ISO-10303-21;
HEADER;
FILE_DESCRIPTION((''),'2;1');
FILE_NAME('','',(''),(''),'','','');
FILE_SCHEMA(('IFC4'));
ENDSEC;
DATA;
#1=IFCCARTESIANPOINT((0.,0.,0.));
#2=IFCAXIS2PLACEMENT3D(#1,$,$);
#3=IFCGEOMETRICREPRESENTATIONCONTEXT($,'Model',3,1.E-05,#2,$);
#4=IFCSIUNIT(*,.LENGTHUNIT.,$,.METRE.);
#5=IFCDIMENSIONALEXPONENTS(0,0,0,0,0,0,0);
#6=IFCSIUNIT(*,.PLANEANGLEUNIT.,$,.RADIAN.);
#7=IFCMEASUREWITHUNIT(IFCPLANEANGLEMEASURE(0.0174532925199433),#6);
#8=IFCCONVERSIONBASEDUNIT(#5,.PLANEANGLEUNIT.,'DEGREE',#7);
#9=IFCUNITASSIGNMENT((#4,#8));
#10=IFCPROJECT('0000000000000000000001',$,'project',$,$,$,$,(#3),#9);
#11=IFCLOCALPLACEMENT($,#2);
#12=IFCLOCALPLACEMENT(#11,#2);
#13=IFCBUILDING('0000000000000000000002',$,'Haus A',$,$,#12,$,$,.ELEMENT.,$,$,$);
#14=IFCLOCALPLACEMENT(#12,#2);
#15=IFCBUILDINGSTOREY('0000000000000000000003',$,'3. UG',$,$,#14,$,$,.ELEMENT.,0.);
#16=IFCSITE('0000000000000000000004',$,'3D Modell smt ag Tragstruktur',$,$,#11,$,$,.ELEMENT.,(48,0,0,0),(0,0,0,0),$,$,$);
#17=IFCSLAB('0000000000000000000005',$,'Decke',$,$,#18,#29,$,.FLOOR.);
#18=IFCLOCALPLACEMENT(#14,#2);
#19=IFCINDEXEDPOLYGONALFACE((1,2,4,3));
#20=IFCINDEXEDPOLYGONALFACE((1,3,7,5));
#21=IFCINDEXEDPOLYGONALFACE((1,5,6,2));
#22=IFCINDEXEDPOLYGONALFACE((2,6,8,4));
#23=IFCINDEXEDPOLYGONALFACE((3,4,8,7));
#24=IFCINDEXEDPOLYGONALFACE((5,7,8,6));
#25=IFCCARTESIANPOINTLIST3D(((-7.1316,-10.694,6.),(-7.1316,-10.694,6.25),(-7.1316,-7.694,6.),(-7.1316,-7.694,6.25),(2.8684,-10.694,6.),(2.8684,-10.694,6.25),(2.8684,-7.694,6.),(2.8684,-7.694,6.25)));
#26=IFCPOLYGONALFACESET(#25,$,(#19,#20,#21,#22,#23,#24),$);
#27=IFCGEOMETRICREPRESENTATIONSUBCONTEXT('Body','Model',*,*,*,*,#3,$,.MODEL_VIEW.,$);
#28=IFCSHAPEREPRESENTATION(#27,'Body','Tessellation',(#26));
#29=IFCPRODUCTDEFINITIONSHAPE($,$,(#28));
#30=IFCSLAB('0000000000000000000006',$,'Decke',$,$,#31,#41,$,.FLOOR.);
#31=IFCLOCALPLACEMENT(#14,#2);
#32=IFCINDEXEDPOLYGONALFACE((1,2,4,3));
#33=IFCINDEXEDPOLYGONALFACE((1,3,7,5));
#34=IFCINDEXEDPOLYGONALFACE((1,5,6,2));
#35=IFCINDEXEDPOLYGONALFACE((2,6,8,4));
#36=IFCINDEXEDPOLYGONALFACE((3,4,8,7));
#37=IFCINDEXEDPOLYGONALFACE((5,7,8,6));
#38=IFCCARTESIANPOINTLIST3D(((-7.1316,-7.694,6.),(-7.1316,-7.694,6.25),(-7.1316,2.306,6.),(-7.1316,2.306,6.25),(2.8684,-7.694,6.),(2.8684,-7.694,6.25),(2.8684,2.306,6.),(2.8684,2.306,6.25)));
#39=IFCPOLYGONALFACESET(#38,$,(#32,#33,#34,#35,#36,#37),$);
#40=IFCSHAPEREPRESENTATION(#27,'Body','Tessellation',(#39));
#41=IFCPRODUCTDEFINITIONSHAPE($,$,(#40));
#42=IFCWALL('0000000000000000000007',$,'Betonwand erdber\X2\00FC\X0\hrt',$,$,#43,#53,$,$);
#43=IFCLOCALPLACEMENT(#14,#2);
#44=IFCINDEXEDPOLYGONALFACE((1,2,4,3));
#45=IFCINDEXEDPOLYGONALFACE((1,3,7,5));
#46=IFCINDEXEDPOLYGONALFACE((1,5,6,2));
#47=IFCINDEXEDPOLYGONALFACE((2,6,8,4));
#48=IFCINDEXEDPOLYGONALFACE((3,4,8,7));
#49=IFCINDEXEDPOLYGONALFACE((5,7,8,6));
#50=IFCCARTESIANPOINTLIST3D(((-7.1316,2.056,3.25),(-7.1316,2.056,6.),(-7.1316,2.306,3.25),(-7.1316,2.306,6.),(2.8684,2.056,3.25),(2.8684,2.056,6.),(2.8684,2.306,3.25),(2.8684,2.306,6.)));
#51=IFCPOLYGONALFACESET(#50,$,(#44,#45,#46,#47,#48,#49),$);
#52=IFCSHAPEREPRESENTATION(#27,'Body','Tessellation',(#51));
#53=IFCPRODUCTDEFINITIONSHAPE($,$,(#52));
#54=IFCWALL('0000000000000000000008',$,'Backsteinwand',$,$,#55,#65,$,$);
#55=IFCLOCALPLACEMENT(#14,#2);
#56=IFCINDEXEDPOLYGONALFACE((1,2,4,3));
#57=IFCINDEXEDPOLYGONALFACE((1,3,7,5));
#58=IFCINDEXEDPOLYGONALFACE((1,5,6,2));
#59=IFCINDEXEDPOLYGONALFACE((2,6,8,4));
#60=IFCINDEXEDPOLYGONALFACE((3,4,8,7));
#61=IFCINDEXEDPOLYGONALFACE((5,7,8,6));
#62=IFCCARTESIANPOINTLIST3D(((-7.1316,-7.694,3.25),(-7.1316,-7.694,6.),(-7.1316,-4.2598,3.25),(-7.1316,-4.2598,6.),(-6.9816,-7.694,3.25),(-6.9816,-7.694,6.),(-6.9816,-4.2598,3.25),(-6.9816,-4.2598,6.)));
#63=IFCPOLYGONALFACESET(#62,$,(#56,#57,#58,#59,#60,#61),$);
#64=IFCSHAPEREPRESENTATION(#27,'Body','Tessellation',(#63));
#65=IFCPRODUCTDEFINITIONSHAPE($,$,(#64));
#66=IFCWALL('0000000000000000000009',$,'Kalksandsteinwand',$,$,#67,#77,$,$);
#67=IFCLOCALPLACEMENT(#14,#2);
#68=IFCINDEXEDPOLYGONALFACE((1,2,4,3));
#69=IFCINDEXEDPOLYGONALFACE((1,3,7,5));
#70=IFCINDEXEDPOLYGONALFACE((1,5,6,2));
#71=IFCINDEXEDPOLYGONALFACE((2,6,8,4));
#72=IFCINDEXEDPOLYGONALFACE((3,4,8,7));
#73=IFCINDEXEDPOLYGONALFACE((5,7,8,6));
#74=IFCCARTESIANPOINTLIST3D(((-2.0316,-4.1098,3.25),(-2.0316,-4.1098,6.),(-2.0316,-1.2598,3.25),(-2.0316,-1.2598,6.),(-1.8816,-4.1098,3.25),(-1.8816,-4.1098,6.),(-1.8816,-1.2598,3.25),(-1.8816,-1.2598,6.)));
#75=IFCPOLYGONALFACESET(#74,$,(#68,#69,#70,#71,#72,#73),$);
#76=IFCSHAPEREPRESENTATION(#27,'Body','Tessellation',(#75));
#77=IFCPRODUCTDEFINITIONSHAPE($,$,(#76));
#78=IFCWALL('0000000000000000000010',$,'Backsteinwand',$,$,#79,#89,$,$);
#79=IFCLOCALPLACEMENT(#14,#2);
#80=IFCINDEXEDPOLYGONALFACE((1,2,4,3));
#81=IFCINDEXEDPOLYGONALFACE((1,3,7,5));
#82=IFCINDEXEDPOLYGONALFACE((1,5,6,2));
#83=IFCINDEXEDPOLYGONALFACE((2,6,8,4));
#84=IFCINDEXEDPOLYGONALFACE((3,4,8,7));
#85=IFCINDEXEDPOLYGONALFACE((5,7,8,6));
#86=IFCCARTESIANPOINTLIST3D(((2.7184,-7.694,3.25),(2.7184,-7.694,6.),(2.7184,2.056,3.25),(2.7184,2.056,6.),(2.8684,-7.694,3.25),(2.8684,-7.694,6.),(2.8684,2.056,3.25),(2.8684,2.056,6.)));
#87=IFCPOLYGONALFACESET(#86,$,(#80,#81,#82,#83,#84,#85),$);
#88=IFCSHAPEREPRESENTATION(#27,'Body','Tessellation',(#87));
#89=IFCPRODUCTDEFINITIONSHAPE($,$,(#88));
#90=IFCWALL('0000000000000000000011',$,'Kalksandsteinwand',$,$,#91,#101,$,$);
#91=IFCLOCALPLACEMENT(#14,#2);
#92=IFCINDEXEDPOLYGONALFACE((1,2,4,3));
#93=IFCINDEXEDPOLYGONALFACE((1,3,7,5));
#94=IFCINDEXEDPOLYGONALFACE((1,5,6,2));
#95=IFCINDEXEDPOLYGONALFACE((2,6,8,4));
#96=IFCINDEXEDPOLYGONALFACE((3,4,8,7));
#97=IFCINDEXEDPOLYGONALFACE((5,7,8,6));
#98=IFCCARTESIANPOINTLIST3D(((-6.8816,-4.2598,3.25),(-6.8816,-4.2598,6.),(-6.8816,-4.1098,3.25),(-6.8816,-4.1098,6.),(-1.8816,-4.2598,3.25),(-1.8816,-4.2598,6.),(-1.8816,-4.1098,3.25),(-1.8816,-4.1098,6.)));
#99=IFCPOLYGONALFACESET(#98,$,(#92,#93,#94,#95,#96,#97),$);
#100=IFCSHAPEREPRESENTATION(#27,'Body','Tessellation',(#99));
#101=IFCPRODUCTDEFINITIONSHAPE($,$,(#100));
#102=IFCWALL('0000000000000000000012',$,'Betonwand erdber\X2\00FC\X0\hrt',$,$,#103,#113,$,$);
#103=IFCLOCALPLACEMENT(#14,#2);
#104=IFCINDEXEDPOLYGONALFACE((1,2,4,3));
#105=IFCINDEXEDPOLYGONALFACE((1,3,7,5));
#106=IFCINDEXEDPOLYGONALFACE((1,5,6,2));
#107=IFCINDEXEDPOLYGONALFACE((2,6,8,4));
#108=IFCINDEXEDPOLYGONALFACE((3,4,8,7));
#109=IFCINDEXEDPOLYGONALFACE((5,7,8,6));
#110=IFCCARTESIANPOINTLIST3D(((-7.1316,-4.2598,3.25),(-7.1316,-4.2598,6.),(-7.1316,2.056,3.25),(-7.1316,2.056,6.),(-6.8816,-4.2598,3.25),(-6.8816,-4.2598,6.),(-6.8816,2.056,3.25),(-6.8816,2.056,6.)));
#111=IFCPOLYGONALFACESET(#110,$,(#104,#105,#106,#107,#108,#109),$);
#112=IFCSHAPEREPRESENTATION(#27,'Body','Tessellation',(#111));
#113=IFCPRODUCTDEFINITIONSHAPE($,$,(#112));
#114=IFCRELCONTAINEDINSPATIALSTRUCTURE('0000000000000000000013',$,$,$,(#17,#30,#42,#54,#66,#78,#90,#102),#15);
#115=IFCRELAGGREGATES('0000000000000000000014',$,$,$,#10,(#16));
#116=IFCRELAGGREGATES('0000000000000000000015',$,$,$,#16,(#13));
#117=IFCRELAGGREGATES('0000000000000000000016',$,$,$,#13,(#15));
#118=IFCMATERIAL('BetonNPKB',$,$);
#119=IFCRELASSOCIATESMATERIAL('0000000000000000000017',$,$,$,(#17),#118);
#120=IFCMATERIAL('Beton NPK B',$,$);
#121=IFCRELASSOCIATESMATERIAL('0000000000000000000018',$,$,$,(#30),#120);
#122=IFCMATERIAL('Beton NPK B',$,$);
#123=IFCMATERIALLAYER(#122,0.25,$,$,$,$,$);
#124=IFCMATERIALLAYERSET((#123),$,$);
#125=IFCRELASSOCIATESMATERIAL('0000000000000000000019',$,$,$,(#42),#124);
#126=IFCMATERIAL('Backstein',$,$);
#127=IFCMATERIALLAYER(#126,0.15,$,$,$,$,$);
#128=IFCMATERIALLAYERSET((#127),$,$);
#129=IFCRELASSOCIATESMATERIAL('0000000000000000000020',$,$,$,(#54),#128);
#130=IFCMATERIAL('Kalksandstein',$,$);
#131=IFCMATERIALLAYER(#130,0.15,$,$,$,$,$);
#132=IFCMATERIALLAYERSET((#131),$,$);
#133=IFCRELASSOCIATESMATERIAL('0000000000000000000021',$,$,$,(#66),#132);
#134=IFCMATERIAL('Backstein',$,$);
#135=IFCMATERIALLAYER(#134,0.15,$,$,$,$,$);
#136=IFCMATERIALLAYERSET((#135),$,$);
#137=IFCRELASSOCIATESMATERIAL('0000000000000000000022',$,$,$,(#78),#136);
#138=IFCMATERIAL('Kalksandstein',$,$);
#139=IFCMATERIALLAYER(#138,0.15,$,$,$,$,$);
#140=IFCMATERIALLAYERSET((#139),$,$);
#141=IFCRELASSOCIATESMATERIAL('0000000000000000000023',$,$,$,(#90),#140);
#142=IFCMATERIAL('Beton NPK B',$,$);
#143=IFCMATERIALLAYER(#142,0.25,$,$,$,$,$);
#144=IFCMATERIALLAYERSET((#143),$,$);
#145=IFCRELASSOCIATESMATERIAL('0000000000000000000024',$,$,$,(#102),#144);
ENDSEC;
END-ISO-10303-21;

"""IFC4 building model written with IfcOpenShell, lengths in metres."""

from ifc_helpers import new_model, entity, si_unit, converted_unit, frame, frame_2d, origin, origin_with_axes, place, context, subcontext, project, spatial, rectangle, extrude, material, layer, layer_set, layer_usage, element, save


model = new_model("IFC4")

# Units and contexts
model_context = context("Model", 3, precision=1e-05, world=origin())
body_context = subcontext(model_context, "Body", "Model", "MODEL_VIEW")
ifc_project = project(units=[si_unit("LENGTHUNIT", "METRE"), converted_unit("PLANEANGLEUNIT", "DEGREE", entity("IfcPlaneAngleMeasure", 0.0174532925199433), si_unit("PLANEANGLEUNIT", "RADIAN"), dimensions=[0, 0, 0, 0, 0, 0, 0])], contexts=[model_context])

# Site, building, storey
site_placement = place(None, origin())
site = spatial("IfcSite", under=ifc_project, at=site_placement, Name="3D Modell smt ag Tragstruktur", CompositionType="ELEMENT", RefLatitude=(48, 0, 0, 0), RefLongitude=(0, 0, 0, 0))
building_placement = place(site_placement, origin())
building = spatial("IfcBuilding", under=site, at=building_placement, Name="Haus A", CompositionType="ELEMENT")
storey_placement = place(building_placement, origin())
storey = spatial("IfcBuildingStorey", under=building, at=storey_placement, Name="3. UG", CompositionType="ELEMENT", Elevation=0.0)

# Slabs
ifc_material_1 = material(Name="BetonNPKB")
slab_1_placement = place(storey_placement, frame((-7.1316, -10.694, 6.0)))
element("IfcSlab", 1, at=slab_1_placement, inside=storey, material=ifc_material_1, Name="Decke", PredefinedType="FLOOR", context=body_context, shape_type="SweptSolid", body=[
    extrude(rectangle(XDim=10.0, YDim=3.0, at=frame_2d((-5.0, -1.5), x_axis=(-1.0, 0.0))), frame((10.0, 3.0, 0.0), z_axis=(0.0, 0.0, 1.0), x_axis=(1.0, 0.0, 0.0)), (0.0, 0.0, 1.0), 0.25),
])
ifc_material_2 = material(Name="Beton NPK B")
slab_2_placement = place(storey_placement, frame((-7.1316, -7.694, 6.0)))
element("IfcSlab", 2, at=slab_2_placement, inside=storey, material=ifc_material_2, Name="Decke", PredefinedType="FLOOR", context=body_context, shape_type="SweptSolid", body=[
    extrude(rectangle(XDim=10.0, YDim=10.0, at=frame_2d((5.0, -5.0), x_axis=(0.0, -1.0))), frame((0.0, 10.0, 0.0), z_axis=(0.0, 0.0, 1.0), x_axis=(1.0, 0.0, 0.0)), (0.0, 0.0, 1.0), 0.25),
])

# Walls
ifc_material_3 = material(Name="Beton NPK B")
ifc_layer_1 = layer(ifc_material_3, 0.25)
ifc_layer_set_1 = layer_set([ifc_layer_1])
ifc_layer_usage_1 = layer_usage(ifc_layer_set_1, "AXIS2", "POSITIVE", 0.0)
wall_1_placement = place(storey_placement, frame((2.8684, 2.306, 3.25), z_axis=(0.0, 0.0, 1.0), x_axis=(-1.0, 0.0, 0.0)))
element("IfcWall", 3, at=wall_1_placement, inside=storey, material=ifc_layer_usage_1, Name="Betonwand erdberührt", context=body_context, shape_type="SweptSolid", body=[
    extrude(rectangle(XDim=10.0, YDim=0.25, at=frame_2d((5.0, 0.125), x_axis=(1.0, 0.0))), origin_with_axes(), (0.0, 0.0, 1.0), 2.75),
])
ifc_material_4 = material(Name="Backstein")
ifc_layer_2 = layer(ifc_material_4, 0.15)
ifc_layer_set_2 = layer_set([ifc_layer_2])
ifc_layer_usage_2 = layer_usage(ifc_layer_set_2, "AXIS2", "POSITIVE", 0.0)
wall_2_placement = place(storey_placement, frame((-7.1316, -4.2598, 3.25), z_axis=(0.0, 0.0, 1.0), x_axis=(0.0, -1.0, 0.0)))
element("IfcWall", 4, at=wall_2_placement, inside=storey, material=ifc_layer_usage_2, Name="Backsteinwand", context=body_context, shape_type="SweptSolid", body=[
    extrude(rectangle(XDim=3.4342, YDim=0.15, at=frame_2d((1.7171, 0.075), x_axis=(1.0, 0.0))), origin_with_axes(), (0.0, 0.0, 1.0), 2.75),
])
ifc_material_5 = material(Name="Kalksandstein")
ifc_layer_3 = layer(ifc_material_5, 0.15)
ifc_layer_set_3 = layer_set([ifc_layer_3])
ifc_layer_usage_3 = layer_usage(ifc_layer_set_3, "AXIS2", "POSITIVE", 0.0)
wall_3_placement = place(storey_placement, frame((-1.8816, -4.1098, 3.25), z_axis=(0.0, 0.0, 1.0), x_axis=(0.0, 1.0, 0.0)))
element("IfcWall", 5, at=wall_3_placement, inside=storey, material=ifc_layer_usage_3, Name="Kalksandsteinwand", context=body_context, shape_type="SweptSolid", body=[
    extrude(rectangle(XDim=2.85, YDim=0.15, at=frame_2d((1.425, 0.075), x_axis=(1.0, 0.0))), origin_with_axes(), (0.0, 0.0, 1.0), 2.75),
])
ifc_material_6 = material(Name="Backstein")
ifc_layer_4 = layer(ifc_material_6, 0.15)
ifc_layer_set_4 = layer_set([ifc_layer_4])
ifc_layer_usage_4 = layer_usage(ifc_layer_set_4, "AXIS2", "POSITIVE", 0.0)
wall_4_placement = place(storey_placement, frame((2.8684, -7.694, 3.25), z_axis=(0.0, 0.0, 1.0), x_axis=(0.0, 1.0, 0.0)))
element("IfcWall", 6, at=wall_4_placement, inside=storey, material=ifc_layer_usage_4, Name="Backsteinwand", context=body_context, shape_type="SweptSolid", body=[
    extrude(rectangle(XDim=9.75, YDim=0.15, at=frame_2d((4.875, 0.075), x_axis=(1.0, 0.0))), origin_with_axes(), (0.0, 0.0, 1.0), 2.75),
])
ifc_material_7 = material(Name="Kalksandstein")
ifc_layer_5 = layer(ifc_material_7, 0.15)
ifc_layer_set_5 = layer_set([ifc_layer_5])
ifc_layer_usage_5 = layer_usage(ifc_layer_set_5, "AXIS2", "POSITIVE", 0.0)
wall_5_placement = place(storey_placement, frame((-6.8816, -4.2598, 3.25)))
element("IfcWall", 7, at=wall_5_placement, inside=storey, material=ifc_layer_usage_5, Name="Kalksandsteinwand", context=body_context, shape_type="SweptSolid", body=[
    extrude(rectangle(XDim=5.0, YDim=0.15, at=frame_2d((2.5, 0.075), x_axis=(1.0, 0.0))), origin_with_axes(), (0.0, 0.0, 1.0), 2.75),
])
ifc_material_8 = material(Name="Beton NPK B")
ifc_layer_6 = layer(ifc_material_8, 0.25)
ifc_layer_set_6 = layer_set([ifc_layer_6])
ifc_layer_usage_6 = layer_usage(ifc_layer_set_6, "AXIS2", "POSITIVE", 0.0)
wall_6_placement = place(storey_placement, frame((-7.1316, 2.056, 3.25), z_axis=(0.0, 0.0, 1.0), x_axis=(0.0, -1.0, 0.0)))
element("IfcWall", 8, at=wall_6_placement, inside=storey, material=ifc_layer_usage_6, Name="Betonwand erdberührt", context=body_context, shape_type="SweptSolid", body=[
    extrude(rectangle(XDim=6.3158, YDim=0.25, at=frame_2d((3.1579, 0.125), x_axis=(1.0, 0.0))), origin_with_axes(), (0.0, 0.0, 1.0), 2.75),
])

save(model, "model.ifc")
